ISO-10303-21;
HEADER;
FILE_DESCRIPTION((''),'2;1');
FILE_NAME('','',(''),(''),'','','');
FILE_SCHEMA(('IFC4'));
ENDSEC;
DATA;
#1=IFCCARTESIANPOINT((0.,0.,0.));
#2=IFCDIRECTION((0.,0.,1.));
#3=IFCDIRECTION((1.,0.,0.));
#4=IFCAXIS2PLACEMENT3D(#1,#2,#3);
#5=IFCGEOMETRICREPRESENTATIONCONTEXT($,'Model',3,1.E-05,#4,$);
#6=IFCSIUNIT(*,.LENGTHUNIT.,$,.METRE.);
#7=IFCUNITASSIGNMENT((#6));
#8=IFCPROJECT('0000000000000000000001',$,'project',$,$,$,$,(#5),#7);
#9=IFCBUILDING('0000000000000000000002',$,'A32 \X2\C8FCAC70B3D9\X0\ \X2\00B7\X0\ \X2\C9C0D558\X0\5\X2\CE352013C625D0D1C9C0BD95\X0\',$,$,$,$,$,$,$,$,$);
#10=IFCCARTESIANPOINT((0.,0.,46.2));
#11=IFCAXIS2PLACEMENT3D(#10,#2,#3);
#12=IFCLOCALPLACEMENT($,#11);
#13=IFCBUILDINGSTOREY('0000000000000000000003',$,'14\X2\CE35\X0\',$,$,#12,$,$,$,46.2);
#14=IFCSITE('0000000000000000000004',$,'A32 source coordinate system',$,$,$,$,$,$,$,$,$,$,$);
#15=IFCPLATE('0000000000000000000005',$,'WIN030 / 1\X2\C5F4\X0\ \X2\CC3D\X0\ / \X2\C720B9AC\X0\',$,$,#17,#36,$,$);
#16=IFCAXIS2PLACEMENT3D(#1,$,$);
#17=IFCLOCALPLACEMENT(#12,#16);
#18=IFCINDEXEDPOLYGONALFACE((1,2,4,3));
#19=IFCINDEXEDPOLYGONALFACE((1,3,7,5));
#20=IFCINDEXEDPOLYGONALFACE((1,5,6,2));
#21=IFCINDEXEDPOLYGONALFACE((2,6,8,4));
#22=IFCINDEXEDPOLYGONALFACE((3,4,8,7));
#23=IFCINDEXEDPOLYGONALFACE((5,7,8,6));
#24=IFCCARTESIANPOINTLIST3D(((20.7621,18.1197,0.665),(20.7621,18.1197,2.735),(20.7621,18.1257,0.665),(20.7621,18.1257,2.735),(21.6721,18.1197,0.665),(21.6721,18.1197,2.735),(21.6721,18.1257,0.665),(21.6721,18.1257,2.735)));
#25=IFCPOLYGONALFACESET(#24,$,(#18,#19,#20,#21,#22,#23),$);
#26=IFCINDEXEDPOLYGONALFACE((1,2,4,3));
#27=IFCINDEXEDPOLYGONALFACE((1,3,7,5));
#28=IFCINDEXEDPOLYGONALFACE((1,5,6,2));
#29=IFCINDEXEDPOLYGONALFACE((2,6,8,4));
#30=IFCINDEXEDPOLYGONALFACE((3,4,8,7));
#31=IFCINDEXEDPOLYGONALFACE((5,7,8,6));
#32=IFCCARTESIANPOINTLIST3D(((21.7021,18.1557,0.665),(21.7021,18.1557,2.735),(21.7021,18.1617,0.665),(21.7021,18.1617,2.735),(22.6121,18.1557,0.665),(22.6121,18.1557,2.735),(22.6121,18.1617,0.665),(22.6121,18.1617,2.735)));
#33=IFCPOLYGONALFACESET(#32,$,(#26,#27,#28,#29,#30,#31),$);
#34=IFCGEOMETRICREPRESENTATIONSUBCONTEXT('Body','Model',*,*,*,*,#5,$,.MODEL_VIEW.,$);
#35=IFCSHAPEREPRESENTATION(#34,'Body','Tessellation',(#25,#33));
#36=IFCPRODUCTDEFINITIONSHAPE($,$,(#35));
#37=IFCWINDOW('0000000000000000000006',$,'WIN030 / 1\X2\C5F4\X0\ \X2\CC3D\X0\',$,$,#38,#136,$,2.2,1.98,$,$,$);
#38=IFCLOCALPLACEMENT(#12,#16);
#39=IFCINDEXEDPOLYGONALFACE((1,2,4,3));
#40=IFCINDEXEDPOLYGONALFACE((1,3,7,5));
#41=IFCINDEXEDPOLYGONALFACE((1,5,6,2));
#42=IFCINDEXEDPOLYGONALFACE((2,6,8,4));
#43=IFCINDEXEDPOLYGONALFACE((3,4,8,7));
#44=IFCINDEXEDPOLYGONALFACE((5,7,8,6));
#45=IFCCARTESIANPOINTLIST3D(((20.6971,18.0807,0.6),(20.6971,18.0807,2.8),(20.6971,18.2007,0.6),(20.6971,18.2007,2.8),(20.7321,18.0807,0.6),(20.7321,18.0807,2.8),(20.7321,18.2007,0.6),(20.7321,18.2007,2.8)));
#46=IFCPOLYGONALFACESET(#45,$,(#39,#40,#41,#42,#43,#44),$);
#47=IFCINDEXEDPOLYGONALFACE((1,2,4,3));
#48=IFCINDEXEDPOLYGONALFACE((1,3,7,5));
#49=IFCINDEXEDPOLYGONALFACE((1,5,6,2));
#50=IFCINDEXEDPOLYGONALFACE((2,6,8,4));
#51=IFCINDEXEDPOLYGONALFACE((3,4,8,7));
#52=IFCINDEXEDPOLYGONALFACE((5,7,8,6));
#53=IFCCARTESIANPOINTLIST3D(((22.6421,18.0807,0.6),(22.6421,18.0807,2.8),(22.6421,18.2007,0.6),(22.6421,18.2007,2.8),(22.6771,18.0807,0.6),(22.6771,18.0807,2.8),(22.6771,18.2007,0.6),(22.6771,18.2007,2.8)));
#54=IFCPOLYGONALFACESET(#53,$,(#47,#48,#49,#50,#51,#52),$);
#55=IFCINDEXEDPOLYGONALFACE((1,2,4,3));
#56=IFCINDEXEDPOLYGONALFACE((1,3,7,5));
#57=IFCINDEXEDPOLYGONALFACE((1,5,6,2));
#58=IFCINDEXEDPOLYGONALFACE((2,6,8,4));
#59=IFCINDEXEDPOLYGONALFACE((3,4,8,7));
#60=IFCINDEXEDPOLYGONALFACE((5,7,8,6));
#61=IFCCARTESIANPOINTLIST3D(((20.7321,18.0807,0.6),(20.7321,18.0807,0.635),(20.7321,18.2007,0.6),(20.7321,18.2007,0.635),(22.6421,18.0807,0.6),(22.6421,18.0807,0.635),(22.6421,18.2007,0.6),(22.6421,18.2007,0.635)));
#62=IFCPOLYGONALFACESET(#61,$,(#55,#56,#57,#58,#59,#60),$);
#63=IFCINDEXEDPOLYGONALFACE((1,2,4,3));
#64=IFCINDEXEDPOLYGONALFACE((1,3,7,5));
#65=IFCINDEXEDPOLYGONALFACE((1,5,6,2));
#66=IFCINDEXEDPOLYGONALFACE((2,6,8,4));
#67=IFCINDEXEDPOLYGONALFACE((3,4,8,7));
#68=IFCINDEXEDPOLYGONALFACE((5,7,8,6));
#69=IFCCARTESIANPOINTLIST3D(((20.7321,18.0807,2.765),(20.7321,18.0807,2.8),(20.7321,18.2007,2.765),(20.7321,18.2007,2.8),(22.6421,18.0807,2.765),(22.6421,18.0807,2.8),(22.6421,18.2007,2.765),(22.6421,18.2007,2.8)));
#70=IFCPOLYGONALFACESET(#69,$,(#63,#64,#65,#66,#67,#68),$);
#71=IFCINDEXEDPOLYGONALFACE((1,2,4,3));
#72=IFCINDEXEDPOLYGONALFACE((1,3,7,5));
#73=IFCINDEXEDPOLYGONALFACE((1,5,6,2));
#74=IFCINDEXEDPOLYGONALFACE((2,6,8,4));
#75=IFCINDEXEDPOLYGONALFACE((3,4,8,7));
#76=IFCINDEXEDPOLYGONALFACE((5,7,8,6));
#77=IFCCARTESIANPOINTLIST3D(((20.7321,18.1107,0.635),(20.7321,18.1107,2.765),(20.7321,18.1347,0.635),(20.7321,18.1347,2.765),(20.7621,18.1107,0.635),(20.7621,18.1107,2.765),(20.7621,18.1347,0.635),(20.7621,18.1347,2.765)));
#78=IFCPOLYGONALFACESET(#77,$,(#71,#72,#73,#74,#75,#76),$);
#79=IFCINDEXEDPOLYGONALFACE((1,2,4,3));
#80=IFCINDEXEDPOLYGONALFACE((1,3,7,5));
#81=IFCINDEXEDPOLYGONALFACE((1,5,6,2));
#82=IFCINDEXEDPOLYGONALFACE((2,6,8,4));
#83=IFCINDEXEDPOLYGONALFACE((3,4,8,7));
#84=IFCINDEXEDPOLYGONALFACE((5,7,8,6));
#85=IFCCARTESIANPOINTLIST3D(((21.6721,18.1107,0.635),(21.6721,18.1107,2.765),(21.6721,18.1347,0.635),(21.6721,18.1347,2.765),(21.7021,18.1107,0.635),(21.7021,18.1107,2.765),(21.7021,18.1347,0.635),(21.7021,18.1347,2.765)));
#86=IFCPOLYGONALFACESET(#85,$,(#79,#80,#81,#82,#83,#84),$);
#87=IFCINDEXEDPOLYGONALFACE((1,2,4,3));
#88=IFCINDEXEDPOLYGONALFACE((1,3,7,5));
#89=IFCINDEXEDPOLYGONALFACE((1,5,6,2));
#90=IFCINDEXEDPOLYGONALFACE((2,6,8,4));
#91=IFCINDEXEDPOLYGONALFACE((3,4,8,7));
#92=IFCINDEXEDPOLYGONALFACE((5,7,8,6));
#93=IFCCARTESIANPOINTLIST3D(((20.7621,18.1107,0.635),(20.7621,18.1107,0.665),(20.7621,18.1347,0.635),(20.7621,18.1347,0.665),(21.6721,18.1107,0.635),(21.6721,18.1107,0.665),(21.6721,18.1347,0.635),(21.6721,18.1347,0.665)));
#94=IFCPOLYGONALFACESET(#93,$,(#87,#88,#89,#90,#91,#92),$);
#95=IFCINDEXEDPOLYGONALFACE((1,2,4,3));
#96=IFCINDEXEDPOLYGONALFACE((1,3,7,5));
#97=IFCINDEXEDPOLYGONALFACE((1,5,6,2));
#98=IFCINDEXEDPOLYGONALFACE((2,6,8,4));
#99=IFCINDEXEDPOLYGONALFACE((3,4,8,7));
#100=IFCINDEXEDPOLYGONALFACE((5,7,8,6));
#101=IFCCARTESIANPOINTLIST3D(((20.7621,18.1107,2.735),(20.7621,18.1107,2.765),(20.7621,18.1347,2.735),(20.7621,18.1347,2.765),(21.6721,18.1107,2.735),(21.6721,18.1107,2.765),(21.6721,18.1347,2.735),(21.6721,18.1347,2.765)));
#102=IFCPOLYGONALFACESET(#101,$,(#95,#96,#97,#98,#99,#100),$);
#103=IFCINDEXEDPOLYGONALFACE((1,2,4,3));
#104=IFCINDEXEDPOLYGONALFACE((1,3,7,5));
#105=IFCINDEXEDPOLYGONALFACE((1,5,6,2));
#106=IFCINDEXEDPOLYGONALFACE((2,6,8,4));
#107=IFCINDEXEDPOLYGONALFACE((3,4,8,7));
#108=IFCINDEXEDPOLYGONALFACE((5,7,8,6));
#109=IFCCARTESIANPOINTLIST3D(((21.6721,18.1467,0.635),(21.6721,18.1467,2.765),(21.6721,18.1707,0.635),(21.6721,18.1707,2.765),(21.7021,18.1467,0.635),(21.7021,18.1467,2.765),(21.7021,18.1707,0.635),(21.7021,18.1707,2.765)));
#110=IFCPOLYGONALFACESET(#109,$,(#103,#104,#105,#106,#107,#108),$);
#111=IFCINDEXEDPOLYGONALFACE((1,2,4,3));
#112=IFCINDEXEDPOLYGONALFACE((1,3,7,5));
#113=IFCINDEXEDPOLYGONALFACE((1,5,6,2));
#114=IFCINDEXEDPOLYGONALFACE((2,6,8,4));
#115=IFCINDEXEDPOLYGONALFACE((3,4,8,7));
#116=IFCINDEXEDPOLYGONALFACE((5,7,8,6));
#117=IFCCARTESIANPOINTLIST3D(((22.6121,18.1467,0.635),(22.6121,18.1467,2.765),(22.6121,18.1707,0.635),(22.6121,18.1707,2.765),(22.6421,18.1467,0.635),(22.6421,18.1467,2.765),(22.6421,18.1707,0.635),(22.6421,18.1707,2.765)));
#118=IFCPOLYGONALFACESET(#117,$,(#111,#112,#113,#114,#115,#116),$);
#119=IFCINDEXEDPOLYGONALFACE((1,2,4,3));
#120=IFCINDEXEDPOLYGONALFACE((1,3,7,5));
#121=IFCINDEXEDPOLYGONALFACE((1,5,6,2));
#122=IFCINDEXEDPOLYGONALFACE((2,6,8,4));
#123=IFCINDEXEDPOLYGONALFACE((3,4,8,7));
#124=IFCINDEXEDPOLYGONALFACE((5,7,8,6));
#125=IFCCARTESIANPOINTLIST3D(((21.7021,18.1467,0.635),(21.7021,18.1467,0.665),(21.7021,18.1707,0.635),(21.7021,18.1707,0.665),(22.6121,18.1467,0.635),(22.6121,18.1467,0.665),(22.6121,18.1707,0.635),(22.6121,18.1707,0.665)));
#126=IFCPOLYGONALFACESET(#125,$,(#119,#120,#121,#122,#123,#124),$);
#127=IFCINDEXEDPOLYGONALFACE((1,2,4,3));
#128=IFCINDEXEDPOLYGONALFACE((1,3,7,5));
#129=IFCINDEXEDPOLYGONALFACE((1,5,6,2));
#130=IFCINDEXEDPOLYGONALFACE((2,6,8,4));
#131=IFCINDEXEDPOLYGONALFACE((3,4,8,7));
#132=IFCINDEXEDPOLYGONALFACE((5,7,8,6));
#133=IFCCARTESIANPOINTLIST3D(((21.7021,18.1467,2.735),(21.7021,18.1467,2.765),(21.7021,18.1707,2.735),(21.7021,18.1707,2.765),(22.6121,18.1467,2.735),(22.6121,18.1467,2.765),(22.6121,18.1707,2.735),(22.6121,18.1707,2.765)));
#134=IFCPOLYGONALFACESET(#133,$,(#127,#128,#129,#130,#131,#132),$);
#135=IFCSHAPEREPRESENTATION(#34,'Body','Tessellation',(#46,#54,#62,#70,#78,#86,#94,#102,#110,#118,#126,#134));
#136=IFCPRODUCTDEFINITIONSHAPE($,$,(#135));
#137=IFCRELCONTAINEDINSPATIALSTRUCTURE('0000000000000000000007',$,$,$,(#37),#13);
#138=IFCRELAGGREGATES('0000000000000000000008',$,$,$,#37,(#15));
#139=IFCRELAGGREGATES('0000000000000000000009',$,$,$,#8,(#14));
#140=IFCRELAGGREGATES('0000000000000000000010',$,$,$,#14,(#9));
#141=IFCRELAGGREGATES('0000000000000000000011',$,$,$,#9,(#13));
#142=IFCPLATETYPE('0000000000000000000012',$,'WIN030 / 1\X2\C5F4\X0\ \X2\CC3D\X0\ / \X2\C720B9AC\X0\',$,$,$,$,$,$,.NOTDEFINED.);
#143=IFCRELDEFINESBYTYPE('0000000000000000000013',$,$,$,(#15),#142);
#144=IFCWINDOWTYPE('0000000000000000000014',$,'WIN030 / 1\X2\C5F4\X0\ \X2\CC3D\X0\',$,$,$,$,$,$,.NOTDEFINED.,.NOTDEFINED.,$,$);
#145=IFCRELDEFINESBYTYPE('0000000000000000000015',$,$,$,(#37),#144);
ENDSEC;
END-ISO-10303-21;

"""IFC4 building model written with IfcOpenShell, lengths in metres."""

from ifc_helpers import new_model, si_unit, frame, origin, origin_with_axes, place, context, subcontext, project, spatial, polyline, outline, extrude, source, transform, mapped, type_object, type_shapes, element, aggregate, save


model = new_model("IFC4")

# Units and contexts
model_context = context("Model", 3, precision=1e-05, world=origin_with_axes())
body_context = subcontext(model_context, "Body", "Model", "MODEL_VIEW")
ifc_project = project(units=[si_unit("LENGTHUNIT", "METRE")], contexts=[model_context])

# Plate
storey_placement = place(None, frame((0.0, 0.0, 46.2), z_axis=(0.0, 0.0, 1.0), x_axis=(1.0, 0.0, 0.0)))
plate_type_1 = type_object("IfcPlateType", Name="WIN030 / 1열 창 / 유리", PredefinedType="NOTDEFINED")
shared_shape_1 = source(origin(), body_context, "Body", "SweptSolid", [
    extrude(outline(polyline([(20.7621, 18.1197), (20.7621, 18.1257), (21.6721, 18.1257), (21.6721, 18.1197), (20.7621, 18.1197)])), frame((0.0, 0.0, 0.665)), (0.0, 0.0, 1.0), 2.07),
    extrude(outline(polyline([(21.7021, 18.1557), (21.7021, 18.1617), (22.6121, 18.1617), (22.6121, 18.1557), (21.7021, 18.1557)])), frame((0.0, 0.0, 0.665)), (0.0, 0.0, 1.0), 2.07),
])
type_shapes(plate_type_1, [shared_shape_1])
window_1_placement = place(storey_placement, origin_with_axes())
plate_1_placement = place(window_1_placement, origin_with_axes())
plate_1 = element("IfcPlate", 1, at=plate_1_placement, type_object=plate_type_1, Name="WIN030 / 1열 창 / 유리", context=body_context, shape_type="MappedRepresentation", body=[
    mapped(shared_shape_1, transform((0.0, 0.0, 0.0), scale=1.0)),
])

# Site, building, storey
site = spatial("IfcSite", under=ifc_project, Name="A32 source coordinate system")
building = spatial("IfcBuilding", under=site, Name="A32 주거동 · 지하5층–옥탑지붕")
storey = spatial("IfcBuildingStorey", under=building, at=storey_placement, Name="14층", Elevation=46.2)

# Window
window_type_1 = type_object("IfcWindowType", Name="WIN030 / 1열 창", PartitioningType="NOTDEFINED", PredefinedType="NOTDEFINED")
shared_shape_2 = source(origin(), body_context, "Body", "SweptSolid", [
    extrude(outline(polyline([(20.6971, 18.0807), (20.6971, 18.2007), (20.7321, 18.2007), (20.7321, 18.0807), (20.6971, 18.0807)])), frame((0.0, 0.0, 0.6)), (0.0, 0.0, 1.0), 2.2),
    extrude(outline(polyline([(22.6421, 18.0807), (22.6421, 18.2007), (22.6771, 18.2007), (22.6771, 18.0807), (22.6421, 18.0807)])), frame((0.0, 0.0, 0.6)), (0.0, 0.0, 1.0), 2.2),
    extrude(outline(polyline([(20.7321, 18.0807), (20.7321, 18.2007), (22.6421, 18.2007), (22.6421, 18.0807), (20.7321, 18.0807)])), frame((0.0, 0.0, 0.6)), (0.0, 0.0, 1.0), 0.035),
    extrude(outline(polyline([(20.7321, 18.0807), (20.7321, 18.2007), (22.6421, 18.2007), (22.6421, 18.0807), (20.7321, 18.0807)])), frame((0.0, 0.0, 2.765)), (0.0, 0.0, 1.0), 0.035),
    extrude(outline(polyline([(20.7321, 18.1107), (20.7321, 18.1347), (20.7621, 18.1347), (20.7621, 18.1107), (20.7321, 18.1107)])), frame((0.0, 0.0, 0.635)), (0.0, 0.0, 1.0), 2.13),
    extrude(outline(polyline([(21.6721, 18.1107), (21.6721, 18.1347), (21.7021, 18.1347), (21.7021, 18.1107), (21.6721, 18.1107)])), frame((0.0, 0.0, 0.635)), (0.0, 0.0, 1.0), 2.13),
    extrude(outline(polyline([(20.7621, 18.1107), (20.7621, 18.1347), (21.6721, 18.1347), (21.6721, 18.1107), (20.7621, 18.1107)])), frame((0.0, 0.0, 0.635)), (0.0, 0.0, 1.0), 0.03),
    extrude(outline(polyline([(20.7621, 18.1107), (20.7621, 18.1347), (21.6721, 18.1347), (21.6721, 18.1107), (20.7621, 18.1107)])), frame((0.0, 0.0, 2.735)), (0.0, 0.0, 1.0), 0.03),
    extrude(outline(polyline([(21.6721, 18.1467), (21.6721, 18.1707), (21.7021, 18.1707), (21.7021, 18.1467), (21.6721, 18.1467)])), frame((0.0, 0.0, 0.635)), (0.0, 0.0, 1.0), 2.13),
    extrude(outline(polyline([(22.6121, 18.1467), (22.6121, 18.1707), (22.6421, 18.1707), (22.6421, 18.1467), (22.6121, 18.1467)])), frame((0.0, 0.0, 0.635)), (0.0, 0.0, 1.0), 2.13),
    extrude(outline(polyline([(21.7021, 18.1467), (21.7021, 18.1707), (22.6121, 18.1707), (22.6121, 18.1467), (21.7021, 18.1467)])), frame((0.0, 0.0, 0.635)), (0.0, 0.0, 1.0), 0.03),
    extrude(outline(polyline([(21.7021, 18.1467), (21.7021, 18.1707), (22.6121, 18.1707), (22.6121, 18.1467), (21.7021, 18.1467)])), frame((0.0, 0.0, 2.735)), (0.0, 0.0, 1.0), 0.03),
])
type_shapes(window_type_1, [shared_shape_2])
window_1 = element("IfcWindow", 2, at=window_1_placement, inside=storey, type_object=window_type_1, Name="WIN030 / 1열 창", OverallHeight=2.2, OverallWidth=1.98, context=body_context, shape_type="MappedRepresentation", body=[
    mapped(shared_shape_2, transform((0.0, 0.0, 0.0), scale=1.0)),
])
aggregate(window_1, [plate_1])

save(model, "model.ifc")
